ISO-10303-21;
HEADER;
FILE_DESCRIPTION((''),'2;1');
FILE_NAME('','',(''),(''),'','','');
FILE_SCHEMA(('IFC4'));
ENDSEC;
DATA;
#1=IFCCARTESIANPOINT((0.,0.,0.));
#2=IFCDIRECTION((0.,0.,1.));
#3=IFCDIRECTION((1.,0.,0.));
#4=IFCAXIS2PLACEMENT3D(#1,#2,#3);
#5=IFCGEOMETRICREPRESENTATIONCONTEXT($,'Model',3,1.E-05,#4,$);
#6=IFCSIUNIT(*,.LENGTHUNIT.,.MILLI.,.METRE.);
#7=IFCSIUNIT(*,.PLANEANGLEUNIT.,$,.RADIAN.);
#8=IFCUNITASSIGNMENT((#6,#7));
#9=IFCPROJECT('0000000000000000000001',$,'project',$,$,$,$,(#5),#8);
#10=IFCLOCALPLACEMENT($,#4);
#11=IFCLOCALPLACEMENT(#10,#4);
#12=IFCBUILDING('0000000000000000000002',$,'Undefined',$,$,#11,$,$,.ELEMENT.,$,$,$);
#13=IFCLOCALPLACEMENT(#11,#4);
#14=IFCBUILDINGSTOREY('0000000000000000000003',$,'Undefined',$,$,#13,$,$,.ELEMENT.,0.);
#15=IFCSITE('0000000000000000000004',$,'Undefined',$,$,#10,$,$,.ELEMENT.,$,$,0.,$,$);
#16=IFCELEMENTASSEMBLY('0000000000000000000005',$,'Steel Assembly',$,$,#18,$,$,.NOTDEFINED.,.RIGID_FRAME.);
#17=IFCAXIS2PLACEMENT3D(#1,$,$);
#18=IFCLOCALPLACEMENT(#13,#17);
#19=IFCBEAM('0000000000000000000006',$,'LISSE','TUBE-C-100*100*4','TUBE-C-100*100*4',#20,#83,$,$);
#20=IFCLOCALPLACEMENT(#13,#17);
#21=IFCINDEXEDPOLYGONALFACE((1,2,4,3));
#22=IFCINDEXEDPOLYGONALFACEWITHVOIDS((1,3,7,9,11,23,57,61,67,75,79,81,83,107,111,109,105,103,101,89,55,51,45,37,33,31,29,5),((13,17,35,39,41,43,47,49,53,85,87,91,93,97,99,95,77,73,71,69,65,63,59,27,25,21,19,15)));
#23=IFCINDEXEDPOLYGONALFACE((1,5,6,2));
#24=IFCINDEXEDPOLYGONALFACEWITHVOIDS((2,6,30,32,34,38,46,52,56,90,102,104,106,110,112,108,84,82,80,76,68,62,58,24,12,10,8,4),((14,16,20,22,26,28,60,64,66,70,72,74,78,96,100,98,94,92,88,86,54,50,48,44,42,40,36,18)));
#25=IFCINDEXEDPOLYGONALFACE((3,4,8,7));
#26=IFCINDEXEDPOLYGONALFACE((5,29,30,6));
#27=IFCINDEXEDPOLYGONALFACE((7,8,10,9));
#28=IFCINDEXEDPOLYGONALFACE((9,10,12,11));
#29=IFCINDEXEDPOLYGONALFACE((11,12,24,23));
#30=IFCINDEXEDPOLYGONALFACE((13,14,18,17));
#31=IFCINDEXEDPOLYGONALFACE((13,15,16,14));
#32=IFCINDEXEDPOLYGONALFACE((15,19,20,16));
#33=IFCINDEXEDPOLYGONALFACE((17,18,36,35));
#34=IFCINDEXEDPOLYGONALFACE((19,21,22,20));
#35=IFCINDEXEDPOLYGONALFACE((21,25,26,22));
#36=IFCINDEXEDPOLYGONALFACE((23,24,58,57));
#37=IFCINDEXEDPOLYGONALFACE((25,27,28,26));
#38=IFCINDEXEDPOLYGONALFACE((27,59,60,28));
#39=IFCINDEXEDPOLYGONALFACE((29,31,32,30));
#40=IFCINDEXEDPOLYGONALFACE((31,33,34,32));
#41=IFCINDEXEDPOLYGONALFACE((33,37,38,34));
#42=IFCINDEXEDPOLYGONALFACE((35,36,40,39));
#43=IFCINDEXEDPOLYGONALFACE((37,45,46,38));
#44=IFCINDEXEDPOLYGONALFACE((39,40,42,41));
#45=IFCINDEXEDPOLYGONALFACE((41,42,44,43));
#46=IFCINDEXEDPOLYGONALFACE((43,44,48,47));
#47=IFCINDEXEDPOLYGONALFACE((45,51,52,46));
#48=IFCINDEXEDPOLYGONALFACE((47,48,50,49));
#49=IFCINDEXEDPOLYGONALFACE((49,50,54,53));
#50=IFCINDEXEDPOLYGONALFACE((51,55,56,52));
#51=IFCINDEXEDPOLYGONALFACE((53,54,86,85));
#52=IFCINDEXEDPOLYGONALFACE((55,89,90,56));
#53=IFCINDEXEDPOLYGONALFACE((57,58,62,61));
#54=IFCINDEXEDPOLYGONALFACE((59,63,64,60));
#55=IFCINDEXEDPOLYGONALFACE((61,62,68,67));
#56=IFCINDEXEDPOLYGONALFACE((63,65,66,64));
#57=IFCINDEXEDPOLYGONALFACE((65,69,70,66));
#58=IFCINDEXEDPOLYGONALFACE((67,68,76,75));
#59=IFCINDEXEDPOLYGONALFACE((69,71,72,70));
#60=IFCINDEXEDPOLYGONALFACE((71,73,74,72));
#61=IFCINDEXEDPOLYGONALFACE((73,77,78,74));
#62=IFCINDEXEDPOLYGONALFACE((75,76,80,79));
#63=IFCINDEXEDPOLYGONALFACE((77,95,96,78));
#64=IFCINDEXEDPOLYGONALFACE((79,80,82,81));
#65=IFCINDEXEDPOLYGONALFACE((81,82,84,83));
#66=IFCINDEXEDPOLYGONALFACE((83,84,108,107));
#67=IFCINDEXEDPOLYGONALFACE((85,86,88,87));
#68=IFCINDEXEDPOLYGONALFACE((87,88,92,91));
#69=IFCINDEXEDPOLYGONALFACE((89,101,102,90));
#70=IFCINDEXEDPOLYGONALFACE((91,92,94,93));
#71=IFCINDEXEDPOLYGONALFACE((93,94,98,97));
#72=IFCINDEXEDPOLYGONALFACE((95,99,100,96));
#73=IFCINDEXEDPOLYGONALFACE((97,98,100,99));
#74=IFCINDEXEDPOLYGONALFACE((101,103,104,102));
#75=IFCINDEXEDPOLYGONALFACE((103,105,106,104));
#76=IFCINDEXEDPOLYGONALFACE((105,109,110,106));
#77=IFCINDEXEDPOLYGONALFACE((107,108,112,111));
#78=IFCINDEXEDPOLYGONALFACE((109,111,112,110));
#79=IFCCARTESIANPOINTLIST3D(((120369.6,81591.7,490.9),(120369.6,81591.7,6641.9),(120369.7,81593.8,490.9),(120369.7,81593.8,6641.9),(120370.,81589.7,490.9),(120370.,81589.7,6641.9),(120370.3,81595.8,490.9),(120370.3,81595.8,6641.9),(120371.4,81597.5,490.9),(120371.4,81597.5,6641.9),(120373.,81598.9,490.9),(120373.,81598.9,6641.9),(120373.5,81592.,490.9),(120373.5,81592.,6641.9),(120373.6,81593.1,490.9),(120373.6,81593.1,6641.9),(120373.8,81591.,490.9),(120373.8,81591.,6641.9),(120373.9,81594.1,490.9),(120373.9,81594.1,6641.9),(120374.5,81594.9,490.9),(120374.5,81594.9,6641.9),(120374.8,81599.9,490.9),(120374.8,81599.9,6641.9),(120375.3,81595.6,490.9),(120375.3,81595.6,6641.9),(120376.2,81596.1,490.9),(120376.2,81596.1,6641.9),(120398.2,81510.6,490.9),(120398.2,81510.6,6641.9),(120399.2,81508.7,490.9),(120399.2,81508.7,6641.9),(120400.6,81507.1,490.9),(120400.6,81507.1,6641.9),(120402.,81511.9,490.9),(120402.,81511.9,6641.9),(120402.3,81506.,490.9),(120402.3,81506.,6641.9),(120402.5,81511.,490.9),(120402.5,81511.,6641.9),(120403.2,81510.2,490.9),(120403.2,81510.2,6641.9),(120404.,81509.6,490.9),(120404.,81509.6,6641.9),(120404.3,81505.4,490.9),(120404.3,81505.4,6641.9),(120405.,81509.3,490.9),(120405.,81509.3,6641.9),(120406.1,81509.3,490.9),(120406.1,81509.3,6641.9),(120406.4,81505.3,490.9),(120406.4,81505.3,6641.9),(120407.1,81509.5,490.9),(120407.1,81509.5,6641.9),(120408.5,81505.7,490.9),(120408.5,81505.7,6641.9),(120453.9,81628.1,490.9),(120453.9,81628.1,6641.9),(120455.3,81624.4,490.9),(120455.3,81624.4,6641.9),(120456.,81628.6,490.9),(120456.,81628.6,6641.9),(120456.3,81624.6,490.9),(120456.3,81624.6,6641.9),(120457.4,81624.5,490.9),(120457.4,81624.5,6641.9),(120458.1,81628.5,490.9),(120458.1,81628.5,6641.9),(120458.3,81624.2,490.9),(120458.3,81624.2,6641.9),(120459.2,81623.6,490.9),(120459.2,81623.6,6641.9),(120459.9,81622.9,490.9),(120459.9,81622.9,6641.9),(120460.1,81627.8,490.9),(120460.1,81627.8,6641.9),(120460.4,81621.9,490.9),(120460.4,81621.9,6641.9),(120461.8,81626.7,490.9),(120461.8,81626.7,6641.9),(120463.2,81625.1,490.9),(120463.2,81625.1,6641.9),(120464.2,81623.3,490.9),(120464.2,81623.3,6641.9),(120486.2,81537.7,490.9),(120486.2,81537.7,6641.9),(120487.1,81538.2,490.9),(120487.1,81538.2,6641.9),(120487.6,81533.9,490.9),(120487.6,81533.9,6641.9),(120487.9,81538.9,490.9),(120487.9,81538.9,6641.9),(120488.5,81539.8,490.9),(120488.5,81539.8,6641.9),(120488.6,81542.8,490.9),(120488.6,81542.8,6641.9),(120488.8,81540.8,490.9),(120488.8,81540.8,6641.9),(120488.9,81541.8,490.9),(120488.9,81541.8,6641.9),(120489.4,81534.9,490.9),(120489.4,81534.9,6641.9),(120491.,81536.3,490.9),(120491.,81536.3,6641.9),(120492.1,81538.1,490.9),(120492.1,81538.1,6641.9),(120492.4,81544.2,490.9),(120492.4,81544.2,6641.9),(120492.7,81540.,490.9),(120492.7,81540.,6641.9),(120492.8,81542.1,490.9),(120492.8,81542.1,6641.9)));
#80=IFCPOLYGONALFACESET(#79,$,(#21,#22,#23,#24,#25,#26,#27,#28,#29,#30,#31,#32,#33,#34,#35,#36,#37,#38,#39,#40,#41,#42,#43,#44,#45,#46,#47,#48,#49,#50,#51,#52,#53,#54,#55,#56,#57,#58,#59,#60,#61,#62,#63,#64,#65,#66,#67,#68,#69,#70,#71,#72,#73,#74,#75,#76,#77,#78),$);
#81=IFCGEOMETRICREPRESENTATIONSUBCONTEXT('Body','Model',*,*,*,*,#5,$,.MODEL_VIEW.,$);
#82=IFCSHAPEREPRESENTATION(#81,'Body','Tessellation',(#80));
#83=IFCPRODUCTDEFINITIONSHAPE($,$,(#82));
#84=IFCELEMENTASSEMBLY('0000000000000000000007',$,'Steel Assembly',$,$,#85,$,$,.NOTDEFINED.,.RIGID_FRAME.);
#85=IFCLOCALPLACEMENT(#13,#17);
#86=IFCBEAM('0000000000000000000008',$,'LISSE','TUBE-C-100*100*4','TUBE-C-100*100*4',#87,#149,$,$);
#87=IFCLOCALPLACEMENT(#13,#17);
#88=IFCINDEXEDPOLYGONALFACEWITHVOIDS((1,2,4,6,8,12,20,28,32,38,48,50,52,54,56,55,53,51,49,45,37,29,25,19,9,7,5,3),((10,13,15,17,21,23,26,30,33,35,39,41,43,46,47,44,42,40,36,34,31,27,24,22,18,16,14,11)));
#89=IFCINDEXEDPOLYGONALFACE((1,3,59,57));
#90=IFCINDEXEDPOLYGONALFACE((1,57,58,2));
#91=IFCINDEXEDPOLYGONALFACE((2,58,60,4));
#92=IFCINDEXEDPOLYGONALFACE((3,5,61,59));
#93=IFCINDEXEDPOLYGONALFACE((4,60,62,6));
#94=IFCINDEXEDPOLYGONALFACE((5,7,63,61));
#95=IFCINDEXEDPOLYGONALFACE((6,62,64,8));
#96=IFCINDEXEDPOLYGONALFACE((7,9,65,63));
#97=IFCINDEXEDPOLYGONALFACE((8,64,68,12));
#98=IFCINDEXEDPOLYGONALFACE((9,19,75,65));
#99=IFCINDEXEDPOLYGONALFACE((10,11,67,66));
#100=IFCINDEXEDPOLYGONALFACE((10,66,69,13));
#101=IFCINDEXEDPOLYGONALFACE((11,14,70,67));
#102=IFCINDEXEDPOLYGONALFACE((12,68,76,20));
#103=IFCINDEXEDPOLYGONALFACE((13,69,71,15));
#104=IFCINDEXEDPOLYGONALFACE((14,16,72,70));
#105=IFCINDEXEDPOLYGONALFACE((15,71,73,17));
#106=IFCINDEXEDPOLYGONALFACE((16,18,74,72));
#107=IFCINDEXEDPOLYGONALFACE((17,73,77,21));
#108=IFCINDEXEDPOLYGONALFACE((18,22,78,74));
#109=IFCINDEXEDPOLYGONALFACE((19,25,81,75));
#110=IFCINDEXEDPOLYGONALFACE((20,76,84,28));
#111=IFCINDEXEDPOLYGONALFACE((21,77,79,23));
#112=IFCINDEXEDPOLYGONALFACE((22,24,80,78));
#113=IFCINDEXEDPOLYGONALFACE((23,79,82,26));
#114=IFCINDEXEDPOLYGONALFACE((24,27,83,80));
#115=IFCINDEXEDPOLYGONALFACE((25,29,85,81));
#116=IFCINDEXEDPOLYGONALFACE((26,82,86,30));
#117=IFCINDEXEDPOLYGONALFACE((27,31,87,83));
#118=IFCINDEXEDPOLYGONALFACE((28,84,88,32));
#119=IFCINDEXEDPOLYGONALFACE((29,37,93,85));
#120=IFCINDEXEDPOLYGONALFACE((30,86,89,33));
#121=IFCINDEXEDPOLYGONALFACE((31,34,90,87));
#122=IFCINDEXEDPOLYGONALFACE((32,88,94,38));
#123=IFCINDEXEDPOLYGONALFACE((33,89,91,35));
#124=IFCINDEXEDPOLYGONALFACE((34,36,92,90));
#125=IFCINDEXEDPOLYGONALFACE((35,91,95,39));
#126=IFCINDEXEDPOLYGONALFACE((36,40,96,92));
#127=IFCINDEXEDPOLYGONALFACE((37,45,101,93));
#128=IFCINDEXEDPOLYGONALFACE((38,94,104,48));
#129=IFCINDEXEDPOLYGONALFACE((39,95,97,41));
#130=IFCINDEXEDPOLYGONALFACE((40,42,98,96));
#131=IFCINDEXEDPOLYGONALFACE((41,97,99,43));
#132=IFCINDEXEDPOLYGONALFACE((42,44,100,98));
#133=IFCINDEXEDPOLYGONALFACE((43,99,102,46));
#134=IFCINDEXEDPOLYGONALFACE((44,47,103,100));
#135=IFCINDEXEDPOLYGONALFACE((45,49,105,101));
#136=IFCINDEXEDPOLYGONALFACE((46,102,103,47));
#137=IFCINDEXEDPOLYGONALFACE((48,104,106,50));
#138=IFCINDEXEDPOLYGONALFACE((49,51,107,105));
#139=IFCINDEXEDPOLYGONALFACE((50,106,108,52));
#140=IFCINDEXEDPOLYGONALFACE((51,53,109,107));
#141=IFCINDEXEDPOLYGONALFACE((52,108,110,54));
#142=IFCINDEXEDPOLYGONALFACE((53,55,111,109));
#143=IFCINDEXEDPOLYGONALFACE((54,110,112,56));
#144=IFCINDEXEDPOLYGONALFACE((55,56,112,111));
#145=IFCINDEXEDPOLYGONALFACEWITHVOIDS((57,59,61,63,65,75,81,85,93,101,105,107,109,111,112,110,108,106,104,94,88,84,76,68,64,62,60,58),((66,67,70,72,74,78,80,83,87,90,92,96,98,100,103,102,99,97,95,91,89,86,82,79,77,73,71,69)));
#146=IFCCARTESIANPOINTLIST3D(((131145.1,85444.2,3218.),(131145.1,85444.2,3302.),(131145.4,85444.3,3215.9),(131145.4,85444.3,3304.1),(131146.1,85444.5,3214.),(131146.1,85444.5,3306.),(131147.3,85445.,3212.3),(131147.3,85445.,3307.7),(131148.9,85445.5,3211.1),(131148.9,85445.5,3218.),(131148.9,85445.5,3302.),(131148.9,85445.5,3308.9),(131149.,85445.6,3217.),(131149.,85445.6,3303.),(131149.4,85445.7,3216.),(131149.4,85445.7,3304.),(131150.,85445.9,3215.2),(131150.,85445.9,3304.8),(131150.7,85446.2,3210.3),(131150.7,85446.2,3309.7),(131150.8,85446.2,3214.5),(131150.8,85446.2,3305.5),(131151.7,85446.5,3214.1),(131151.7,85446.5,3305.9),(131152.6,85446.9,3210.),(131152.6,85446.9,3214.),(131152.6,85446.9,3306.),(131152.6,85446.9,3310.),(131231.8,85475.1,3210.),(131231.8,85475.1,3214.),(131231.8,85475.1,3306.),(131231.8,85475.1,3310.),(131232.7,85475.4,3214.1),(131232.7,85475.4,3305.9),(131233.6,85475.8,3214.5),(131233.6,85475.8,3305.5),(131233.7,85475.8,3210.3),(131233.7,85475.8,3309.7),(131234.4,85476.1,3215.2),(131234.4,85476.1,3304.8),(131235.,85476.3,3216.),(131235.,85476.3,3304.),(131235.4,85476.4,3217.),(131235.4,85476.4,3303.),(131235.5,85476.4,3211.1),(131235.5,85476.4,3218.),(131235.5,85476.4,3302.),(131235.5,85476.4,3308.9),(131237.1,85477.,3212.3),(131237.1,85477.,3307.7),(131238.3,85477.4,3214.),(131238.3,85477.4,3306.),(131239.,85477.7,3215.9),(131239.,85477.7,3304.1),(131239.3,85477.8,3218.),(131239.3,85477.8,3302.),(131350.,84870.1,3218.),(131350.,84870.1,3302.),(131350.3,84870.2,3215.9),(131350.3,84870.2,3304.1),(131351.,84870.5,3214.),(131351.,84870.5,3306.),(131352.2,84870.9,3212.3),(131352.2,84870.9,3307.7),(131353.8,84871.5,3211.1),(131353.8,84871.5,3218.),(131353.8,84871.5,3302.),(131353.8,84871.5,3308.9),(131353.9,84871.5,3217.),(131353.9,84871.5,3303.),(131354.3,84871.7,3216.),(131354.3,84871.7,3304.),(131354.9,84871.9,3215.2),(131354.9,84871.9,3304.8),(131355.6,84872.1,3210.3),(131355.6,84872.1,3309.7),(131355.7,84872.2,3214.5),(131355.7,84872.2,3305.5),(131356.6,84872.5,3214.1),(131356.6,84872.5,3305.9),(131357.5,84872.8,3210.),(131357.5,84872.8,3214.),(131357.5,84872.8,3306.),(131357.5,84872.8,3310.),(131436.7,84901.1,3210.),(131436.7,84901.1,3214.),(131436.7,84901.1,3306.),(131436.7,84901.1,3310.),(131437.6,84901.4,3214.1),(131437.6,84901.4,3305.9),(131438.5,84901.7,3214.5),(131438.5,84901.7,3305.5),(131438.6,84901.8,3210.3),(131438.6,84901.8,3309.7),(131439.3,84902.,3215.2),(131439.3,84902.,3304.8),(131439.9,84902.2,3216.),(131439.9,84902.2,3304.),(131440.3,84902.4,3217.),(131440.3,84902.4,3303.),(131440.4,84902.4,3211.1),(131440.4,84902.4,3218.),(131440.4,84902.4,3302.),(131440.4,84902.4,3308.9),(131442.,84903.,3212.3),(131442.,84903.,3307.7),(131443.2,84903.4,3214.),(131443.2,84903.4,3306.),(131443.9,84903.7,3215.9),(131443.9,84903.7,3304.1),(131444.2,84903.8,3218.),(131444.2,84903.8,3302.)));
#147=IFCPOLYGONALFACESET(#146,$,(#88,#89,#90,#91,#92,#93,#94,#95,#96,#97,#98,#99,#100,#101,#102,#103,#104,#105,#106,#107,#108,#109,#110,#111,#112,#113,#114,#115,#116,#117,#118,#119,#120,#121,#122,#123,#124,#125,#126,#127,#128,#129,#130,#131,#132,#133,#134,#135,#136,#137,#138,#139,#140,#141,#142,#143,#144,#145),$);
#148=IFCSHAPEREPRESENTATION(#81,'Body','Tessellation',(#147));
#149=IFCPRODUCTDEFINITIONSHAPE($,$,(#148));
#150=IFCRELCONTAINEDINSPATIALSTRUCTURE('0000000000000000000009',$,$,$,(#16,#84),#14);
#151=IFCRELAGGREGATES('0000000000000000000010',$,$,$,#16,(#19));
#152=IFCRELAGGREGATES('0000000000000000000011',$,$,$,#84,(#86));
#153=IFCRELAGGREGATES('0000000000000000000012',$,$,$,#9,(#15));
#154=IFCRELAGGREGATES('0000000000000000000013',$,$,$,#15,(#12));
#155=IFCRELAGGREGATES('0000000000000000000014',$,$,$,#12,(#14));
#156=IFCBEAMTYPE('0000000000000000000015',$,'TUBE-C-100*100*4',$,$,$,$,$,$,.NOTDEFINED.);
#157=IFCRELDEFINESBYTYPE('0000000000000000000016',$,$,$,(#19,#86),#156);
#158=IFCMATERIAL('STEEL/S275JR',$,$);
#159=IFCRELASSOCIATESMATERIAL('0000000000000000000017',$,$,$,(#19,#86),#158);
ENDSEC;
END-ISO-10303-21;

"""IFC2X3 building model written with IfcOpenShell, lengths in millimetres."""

from ifc_helpers import new_model, si_unit, frame, origin_with_axes, origin_2d_with_axis, place, context, subcontext, project, spatial, hollow_rectangle, extrude, material, type_object, element, aggregate, save


model = new_model("IFC2X3")

# Units and contexts
model_context = context("Model", 3, precision=1e-05, world=origin_with_axes())
body_context = subcontext(model_context, "Body", "Model", "MODEL_VIEW")
ifc_project = project(units=[si_unit("LENGTHUNIT", "METRE", prefix="MILLI"), si_unit("PLANEANGLEUNIT", "RADIAN")], contexts=[model_context])

# Site, building, storey
site_placement = place(None, origin_with_axes())
site = spatial("IfcSite", under=ifc_project, at=site_placement, Name="Undefined", CompositionType="ELEMENT", RefElevation=0.0)
building_placement = place(site_placement, origin_with_axes())
building = spatial("IfcBuilding", under=site, at=building_placement, Name="Undefined", CompositionType="ELEMENT")
storey_placement = place(building_placement, origin_with_axes())
storey = spatial("IfcBuildingStorey", under=building, at=storey_placement, Name="Undefined", CompositionType="ELEMENT", Elevation=0.0)

# Shared definitions
ifc_material = material(Name="STEEL/S275JR")

# Element assemblies, beams
beam_type_1 = type_object("IfcBeamType", Name="TUBE-C-100*100*4", PredefinedType="NOTDEFINED")
assembly_1_placement = place(storey_placement, origin_with_axes())
assembly_1 = element("IfcElementAssembly", 1, at=assembly_1_placement, inside=storey, Name="Steel Assembly", AssemblyPlace="NOTDEFINED", PredefinedType="RIGID_FRAME")
beam_1_placement = place(assembly_1_placement, frame((120431.2, 81566.9, 6641.9), z_axis=(0.941802, 0.336168, 0.0), x_axis=(0.0, 0.0, -1.0)))
beam_1 = element("IfcBeam", 2, at=beam_1_placement, type_object=beam_type_1, material=ifc_material, Name="LISSE", Description="TUBE-C-100*100*4", ObjectType="TUBE-C-100*100*4", context=body_context, shape_type="SweptSolid", body=[
    extrude(hollow_rectangle(XDim=100.0, YDim=100.0, WallThickness=4.0, InnerFilletRadius=4.0, OuterFilletRadius=8.0, at=origin_2d_with_axis()), frame((6151.0, 0.0, 0.0), z_axis=(-1.0, 0.0, 0.0), x_axis=(0.0, -1.0, 0.0)), (0.0, 0.0, 1.0), 6151.0),
])
aggregate(assembly_1, [beam_1])
assembly_2_placement = place(storey_placement, origin_with_axes())
assembly_2 = element("IfcElementAssembly", 3, at=assembly_2_placement, inside=storey, Name="Steel Assembly", AssemblyPlace="NOTDEFINED", PredefinedType="RIGID_FRAME")
beam_2_placement = place(assembly_2_placement, frame((131397.1, 84887.0, 3260.0), z_axis=(0.941802, 0.336169, 0.0), x_axis=(-0.336169, 0.941802, 0.0)))
beam_2 = element("IfcBeam", 4, at=beam_2_placement, type_object=beam_type_1, material=ifc_material, Name="LISSE", Description="TUBE-C-100*100*4", ObjectType="TUBE-C-100*100*4", context=body_context, shape_type="SweptSolid", body=[
    extrude(hollow_rectangle(XDim=100.0, YDim=100.0, WallThickness=4.0, InnerFilletRadius=4.0, OuterFilletRadius=8.0, at=origin_2d_with_axis()), frame((609.5, 0.0, 0.0), z_axis=(-1.0, 0.0, 0.0), x_axis=(0.0, -1.0, 0.0)), (0.0, 0.0, 1.0), 609.5),
])
aggregate(assembly_2, [beam_2])

save(model, "model.ifc")
